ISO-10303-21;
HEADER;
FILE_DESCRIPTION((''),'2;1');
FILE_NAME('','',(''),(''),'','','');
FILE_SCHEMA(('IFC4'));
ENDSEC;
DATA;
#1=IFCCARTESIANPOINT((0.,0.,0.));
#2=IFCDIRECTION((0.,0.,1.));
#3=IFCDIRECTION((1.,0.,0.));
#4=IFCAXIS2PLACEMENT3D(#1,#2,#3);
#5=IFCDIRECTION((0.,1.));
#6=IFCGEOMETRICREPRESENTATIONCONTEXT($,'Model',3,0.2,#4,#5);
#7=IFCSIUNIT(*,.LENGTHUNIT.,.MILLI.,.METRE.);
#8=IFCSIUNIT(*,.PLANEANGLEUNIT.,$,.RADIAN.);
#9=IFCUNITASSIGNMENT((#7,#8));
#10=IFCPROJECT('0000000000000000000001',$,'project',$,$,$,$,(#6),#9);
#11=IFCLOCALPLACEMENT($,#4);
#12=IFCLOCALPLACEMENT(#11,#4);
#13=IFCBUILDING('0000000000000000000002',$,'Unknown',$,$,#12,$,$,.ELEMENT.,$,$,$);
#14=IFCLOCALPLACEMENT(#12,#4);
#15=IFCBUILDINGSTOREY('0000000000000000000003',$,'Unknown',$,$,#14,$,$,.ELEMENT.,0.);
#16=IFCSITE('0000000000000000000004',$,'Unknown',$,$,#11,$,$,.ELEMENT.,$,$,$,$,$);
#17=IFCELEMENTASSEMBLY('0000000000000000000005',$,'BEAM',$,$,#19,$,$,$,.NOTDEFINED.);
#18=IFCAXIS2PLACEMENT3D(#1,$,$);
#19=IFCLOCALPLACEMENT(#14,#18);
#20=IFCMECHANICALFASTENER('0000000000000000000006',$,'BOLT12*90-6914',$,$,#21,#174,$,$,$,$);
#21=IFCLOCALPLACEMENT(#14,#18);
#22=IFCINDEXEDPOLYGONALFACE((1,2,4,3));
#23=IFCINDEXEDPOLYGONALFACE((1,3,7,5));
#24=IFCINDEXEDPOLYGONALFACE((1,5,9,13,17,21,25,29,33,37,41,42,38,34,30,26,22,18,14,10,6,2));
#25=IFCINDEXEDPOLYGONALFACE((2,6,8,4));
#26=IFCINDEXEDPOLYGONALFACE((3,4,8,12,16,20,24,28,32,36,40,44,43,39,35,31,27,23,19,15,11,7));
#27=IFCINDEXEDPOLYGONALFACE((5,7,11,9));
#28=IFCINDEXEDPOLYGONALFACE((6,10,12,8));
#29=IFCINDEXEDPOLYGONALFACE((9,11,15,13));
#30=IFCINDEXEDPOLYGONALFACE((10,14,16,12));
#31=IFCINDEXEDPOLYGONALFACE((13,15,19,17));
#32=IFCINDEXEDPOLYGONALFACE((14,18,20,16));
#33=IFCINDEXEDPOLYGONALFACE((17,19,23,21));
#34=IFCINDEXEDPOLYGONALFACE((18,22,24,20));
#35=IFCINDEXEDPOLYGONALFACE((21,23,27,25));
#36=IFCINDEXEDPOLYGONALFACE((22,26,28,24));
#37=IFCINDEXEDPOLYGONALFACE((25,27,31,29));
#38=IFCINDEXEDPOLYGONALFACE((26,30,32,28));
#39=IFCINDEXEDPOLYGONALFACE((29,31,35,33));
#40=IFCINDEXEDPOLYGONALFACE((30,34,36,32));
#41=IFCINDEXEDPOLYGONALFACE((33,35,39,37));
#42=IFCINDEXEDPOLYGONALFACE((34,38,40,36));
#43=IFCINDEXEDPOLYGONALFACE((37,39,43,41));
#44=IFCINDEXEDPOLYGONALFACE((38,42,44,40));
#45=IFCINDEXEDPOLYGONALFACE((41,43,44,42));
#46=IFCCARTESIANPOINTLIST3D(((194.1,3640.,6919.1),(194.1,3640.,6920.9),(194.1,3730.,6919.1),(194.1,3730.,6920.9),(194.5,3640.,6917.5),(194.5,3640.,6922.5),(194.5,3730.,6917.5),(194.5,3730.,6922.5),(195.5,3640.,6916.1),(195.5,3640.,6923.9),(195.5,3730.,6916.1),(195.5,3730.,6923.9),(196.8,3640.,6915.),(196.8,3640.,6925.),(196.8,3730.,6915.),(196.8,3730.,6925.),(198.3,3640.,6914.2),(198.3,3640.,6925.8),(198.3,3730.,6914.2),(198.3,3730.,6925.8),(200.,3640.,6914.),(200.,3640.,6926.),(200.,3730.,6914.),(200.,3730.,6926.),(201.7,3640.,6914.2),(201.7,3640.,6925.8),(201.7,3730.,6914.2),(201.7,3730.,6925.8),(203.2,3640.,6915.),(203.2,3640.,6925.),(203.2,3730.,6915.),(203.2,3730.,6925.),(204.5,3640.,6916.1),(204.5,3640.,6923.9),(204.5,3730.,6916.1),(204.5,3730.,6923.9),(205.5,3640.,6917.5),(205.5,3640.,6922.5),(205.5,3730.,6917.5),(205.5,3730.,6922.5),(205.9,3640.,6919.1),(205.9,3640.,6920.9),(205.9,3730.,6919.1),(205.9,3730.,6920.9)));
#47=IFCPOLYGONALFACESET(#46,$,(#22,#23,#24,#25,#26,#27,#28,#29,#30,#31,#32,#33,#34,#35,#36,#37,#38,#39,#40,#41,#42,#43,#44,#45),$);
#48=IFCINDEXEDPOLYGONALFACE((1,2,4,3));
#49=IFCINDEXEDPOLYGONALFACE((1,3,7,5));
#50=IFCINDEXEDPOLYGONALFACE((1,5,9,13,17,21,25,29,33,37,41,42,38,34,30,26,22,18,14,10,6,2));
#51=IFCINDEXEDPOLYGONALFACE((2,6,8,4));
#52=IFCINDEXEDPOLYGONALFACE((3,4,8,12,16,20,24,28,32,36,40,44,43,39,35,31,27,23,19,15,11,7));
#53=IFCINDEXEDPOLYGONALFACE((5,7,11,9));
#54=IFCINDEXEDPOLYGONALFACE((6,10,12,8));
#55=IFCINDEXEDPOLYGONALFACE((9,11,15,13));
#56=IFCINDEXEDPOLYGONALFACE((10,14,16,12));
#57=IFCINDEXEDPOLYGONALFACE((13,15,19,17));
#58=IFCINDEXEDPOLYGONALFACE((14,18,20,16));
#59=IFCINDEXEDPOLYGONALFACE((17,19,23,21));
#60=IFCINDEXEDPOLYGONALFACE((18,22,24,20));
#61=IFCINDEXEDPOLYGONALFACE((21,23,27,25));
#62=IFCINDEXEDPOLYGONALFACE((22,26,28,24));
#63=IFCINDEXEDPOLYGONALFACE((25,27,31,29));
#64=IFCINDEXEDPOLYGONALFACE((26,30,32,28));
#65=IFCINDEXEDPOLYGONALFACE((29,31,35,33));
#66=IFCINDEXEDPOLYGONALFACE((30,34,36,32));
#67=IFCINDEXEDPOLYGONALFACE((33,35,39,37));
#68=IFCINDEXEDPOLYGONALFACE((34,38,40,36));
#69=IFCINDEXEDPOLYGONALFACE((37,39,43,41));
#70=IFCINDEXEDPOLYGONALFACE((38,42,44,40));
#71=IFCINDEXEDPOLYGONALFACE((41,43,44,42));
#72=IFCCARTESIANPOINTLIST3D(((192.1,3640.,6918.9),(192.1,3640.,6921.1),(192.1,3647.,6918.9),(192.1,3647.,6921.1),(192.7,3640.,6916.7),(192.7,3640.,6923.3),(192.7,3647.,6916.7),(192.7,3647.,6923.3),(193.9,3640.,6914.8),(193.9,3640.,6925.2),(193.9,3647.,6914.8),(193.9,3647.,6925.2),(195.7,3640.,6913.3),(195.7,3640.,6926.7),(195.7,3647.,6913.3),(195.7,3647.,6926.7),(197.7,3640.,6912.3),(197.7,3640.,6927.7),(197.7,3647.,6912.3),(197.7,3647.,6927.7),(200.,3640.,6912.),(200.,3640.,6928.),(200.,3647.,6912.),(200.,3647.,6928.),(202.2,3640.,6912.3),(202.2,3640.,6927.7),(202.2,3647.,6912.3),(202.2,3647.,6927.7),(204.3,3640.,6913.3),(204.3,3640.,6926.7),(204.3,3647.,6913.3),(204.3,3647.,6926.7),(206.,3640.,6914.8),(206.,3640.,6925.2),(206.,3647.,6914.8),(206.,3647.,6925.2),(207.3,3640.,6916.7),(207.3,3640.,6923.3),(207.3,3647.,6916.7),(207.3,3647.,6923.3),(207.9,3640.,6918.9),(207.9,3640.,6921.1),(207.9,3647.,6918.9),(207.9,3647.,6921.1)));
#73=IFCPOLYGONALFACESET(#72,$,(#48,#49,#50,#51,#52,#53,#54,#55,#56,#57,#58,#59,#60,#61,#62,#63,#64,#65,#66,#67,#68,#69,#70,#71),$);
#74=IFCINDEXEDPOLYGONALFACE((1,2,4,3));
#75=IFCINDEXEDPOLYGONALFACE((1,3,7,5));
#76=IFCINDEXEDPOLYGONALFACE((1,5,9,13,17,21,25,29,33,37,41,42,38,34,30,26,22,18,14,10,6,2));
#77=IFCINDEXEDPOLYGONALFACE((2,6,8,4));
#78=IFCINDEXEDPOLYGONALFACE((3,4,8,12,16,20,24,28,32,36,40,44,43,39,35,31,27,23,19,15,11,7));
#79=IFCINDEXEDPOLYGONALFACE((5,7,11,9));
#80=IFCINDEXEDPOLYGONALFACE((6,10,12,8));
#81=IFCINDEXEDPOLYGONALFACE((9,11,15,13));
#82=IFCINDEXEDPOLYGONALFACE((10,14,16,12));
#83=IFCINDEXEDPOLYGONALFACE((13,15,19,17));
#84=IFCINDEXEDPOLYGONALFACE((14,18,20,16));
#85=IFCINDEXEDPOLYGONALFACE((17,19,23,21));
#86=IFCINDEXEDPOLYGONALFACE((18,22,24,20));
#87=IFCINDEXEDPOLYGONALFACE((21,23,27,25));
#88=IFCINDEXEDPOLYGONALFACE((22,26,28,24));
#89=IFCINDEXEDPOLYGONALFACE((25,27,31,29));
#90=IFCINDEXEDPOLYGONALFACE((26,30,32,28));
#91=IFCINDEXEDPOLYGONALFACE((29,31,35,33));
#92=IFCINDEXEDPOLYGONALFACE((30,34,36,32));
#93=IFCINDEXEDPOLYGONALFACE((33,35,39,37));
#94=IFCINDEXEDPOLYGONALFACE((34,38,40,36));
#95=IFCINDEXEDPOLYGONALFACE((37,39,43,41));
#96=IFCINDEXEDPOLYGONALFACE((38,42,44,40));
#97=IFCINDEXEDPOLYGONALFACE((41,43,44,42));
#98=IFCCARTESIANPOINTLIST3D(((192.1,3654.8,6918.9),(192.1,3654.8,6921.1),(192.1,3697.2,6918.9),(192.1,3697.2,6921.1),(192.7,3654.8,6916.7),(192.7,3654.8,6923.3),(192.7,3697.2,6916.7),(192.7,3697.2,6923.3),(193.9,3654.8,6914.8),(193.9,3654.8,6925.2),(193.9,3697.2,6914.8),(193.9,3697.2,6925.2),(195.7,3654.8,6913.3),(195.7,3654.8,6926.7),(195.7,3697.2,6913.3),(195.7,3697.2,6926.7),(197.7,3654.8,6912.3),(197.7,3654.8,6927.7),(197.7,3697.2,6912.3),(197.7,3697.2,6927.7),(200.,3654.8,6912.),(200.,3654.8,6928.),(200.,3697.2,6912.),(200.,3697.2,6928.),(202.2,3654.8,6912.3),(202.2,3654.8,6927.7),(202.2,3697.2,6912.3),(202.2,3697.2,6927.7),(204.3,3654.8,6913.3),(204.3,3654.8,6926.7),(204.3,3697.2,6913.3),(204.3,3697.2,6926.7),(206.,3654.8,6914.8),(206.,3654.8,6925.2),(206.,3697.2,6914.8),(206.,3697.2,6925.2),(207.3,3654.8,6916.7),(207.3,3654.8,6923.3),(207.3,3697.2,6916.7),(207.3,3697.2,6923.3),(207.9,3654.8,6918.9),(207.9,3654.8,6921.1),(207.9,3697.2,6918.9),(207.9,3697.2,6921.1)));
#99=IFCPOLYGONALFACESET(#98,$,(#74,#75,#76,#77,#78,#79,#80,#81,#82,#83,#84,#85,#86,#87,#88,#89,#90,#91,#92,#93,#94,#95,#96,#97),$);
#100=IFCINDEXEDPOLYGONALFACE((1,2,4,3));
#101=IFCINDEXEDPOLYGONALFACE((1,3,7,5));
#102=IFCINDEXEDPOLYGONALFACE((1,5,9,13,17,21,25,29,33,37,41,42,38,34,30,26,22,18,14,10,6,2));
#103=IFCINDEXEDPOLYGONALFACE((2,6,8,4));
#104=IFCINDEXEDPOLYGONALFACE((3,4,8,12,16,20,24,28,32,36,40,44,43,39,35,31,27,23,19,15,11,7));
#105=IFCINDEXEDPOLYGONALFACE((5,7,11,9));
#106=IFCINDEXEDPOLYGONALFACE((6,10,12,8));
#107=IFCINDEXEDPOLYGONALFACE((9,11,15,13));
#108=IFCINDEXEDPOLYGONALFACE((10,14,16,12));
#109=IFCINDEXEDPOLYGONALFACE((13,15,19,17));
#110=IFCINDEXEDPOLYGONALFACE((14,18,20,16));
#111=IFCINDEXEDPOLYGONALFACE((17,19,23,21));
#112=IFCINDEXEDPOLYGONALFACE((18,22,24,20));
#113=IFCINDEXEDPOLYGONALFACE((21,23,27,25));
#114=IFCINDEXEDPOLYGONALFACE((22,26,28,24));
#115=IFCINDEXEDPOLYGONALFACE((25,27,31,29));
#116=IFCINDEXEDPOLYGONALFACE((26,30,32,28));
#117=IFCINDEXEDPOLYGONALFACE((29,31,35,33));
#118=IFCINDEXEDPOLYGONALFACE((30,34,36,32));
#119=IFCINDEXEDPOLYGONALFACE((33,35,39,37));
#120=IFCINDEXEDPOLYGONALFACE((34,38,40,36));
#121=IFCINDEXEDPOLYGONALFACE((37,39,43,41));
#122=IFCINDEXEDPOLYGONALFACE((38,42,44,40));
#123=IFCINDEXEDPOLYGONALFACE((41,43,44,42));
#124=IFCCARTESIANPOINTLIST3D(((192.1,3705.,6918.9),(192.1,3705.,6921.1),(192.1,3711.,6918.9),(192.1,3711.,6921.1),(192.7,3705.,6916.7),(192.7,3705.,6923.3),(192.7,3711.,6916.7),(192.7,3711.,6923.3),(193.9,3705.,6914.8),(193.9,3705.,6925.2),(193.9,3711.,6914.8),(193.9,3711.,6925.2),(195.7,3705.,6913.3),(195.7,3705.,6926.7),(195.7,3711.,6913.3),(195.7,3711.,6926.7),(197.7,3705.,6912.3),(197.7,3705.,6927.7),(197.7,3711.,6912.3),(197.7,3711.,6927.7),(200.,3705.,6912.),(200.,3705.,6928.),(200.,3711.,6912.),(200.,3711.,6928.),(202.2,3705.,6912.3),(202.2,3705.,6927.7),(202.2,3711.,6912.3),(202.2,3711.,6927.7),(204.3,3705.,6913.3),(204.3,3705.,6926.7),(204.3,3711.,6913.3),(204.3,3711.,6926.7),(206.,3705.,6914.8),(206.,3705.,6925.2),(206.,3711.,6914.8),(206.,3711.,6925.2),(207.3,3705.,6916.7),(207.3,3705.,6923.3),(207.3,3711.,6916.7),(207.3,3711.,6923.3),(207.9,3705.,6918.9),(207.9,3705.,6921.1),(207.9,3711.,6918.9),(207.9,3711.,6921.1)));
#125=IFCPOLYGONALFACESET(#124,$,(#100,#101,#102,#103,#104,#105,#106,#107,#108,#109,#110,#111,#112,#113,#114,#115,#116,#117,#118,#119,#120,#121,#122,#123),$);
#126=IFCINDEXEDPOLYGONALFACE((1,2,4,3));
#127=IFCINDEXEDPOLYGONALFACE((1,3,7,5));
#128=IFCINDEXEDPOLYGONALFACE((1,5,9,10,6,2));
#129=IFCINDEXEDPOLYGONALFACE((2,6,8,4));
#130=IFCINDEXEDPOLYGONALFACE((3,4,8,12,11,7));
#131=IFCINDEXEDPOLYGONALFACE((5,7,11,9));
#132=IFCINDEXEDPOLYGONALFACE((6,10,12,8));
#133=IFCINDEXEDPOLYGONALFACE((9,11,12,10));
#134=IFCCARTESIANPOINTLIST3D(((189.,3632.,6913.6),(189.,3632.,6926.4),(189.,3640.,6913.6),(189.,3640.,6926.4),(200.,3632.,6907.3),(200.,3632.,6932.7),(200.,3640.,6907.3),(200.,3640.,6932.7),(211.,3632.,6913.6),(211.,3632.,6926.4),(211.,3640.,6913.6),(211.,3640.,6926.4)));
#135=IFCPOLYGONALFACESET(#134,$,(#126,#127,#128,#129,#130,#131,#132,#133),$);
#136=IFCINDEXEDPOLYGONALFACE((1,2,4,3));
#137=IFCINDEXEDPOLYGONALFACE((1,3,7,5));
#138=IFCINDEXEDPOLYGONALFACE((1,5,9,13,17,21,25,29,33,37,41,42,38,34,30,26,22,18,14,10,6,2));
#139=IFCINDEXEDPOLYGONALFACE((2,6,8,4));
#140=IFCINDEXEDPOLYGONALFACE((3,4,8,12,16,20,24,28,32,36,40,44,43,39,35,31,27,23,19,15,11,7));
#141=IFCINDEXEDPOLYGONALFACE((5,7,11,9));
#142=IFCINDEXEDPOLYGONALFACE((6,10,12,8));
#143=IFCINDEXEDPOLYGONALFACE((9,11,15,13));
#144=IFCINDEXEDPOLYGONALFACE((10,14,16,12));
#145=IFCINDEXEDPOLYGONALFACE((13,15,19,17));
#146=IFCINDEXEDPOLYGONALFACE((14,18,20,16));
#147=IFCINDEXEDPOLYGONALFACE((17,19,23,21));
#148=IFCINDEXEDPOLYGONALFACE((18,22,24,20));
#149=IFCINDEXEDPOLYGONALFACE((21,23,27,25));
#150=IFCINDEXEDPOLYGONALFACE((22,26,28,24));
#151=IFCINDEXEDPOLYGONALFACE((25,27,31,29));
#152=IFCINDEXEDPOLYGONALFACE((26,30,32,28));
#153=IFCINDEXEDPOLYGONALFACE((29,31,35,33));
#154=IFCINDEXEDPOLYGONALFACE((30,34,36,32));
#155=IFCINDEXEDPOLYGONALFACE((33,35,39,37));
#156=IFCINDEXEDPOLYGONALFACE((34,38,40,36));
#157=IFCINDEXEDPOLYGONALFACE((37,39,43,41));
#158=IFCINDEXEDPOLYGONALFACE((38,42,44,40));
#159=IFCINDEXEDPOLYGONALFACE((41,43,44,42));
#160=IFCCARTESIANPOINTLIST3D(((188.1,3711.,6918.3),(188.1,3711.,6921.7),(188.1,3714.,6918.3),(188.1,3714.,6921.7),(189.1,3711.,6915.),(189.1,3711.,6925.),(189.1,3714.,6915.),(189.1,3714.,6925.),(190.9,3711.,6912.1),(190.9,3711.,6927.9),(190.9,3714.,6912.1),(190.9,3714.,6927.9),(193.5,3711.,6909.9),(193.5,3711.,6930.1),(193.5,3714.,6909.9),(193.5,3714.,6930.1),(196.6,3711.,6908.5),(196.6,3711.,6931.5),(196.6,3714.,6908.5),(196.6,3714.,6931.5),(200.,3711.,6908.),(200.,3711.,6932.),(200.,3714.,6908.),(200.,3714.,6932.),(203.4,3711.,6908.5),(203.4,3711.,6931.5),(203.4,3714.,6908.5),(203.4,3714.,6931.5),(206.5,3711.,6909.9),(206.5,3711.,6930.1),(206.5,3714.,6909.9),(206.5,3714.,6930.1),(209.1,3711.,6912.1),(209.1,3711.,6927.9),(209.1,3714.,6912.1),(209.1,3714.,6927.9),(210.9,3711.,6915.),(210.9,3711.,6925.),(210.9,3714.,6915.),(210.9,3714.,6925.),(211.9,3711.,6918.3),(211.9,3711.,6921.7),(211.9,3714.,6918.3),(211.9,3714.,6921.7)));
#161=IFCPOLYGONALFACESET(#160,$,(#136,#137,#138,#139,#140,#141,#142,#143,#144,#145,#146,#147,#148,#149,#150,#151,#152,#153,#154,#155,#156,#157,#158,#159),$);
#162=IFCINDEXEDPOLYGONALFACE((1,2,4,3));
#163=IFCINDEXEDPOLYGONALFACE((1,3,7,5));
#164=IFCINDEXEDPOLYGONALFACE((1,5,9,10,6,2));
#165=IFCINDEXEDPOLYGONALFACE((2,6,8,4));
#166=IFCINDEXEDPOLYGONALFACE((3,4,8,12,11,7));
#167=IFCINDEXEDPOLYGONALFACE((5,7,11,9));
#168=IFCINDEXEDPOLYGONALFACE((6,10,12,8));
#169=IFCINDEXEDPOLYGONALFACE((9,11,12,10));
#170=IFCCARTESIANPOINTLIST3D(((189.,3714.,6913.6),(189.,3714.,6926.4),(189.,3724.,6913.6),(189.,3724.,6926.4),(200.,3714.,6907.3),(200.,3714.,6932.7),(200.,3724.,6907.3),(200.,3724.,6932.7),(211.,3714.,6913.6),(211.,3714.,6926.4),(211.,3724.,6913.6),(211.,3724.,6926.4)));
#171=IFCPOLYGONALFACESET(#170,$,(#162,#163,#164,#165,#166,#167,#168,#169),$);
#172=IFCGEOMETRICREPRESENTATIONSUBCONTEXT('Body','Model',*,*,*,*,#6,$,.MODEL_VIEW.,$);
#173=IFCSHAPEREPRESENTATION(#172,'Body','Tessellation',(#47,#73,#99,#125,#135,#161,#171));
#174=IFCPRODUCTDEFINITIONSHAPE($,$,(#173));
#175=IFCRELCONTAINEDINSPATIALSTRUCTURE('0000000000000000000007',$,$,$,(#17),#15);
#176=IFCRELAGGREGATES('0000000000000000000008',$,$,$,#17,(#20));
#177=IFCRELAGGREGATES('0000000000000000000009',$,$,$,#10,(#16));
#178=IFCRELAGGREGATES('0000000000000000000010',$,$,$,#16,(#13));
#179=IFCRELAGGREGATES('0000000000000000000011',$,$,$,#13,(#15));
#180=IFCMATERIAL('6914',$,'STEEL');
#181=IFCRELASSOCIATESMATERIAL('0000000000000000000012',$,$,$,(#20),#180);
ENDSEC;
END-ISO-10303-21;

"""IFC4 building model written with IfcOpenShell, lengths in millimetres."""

from ifc_helpers import new_model, si_unit, direction, frame, origin_with_axes, place, context, subcontext, project, spatial, line, arc, indexed_curve, outline, extrude, source, transform, mapped, material, element, aggregate, save


model = new_model("IFC4")

# Units and contexts
model_context = context("Model", 3, precision=0.2, world=origin_with_axes(), true_north=direction((0.0, 1.0)))
body_context = subcontext(model_context, "Body", "Model", "MODEL_VIEW")
ifc_project = project(units=[si_unit("LENGTHUNIT", "METRE", prefix="MILLI"), si_unit("PLANEANGLEUNIT", "RADIAN")], contexts=[model_context])

# Site, building, storey
site_placement = place(None, origin_with_axes())
site = spatial("IfcSite", under=ifc_project, at=site_placement, Name="Unknown", CompositionType="ELEMENT")
building_placement = place(site_placement, origin_with_axes())
building = spatial("IfcBuilding", under=site, at=building_placement, Name="Unknown", CompositionType="ELEMENT")
storey_placement = place(building_placement, origin_with_axes())
storey = spatial("IfcBuildingStorey", under=building, at=storey_placement, Name="Unknown", CompositionType="ELEMENT", Elevation=0.0)

# Element assembly
assembly_1_placement = place(storey_placement, frame((175.5, 3720.0, 6980.0), z_axis=(0.0, -1.0, 0.000002), x_axis=(1.0, 0.0, 0.0)))
assembly_1 = element("IfcElementAssembly", 1, at=assembly_1_placement, inside=storey, Name="BEAM", PredefinedType="NOTDEFINED")

# Mechanical fastener
ifc_material_1 = material(Name="6914", Category="STEEL")
shared_shape_1 = source(origin_with_axes(), body_context, "Body", "SweptSolid", [
    extrude(outline(indexed_curve([(6.0, 0.0), (0.0, 6.0), (-6.0, 0.0), (0.0, -6.0)], segments=[arc(1, 2, 3), arc(3, 4, 1)])), frame((0.0, 0.0, 0.0), z_axis=(0.0, -0.000002, -1.0), x_axis=(0.0, 1.0, 0.0)), (0.0, 0.0, 1.0), 90.0),
    extrude(outline(indexed_curve([(8.0, 0.0), (0.0, 8.0), (-8.0, 0.0), (0.0, -8.0)], segments=[arc(1, 2, 3), arc(3, 4, 1)])), frame((0.0, 0.0, 0.0), z_axis=(0.0, -0.000002, -1.0), x_axis=(0.0, 1.0, 0.0)), (0.0, 0.0, 1.0), 7.0),
    extrude(outline(indexed_curve([(8.0, 0.0), (0.0, 8.0), (-8.0, 0.0), (0.0, -8.0)], segments=[arc(1, 2, 3), arc(3, 4, 1)])), frame((0.0, 0.0, -14.8), z_axis=(0.0, -0.000002, -1.0), x_axis=(0.0, 1.0, 0.0)), (0.0, 0.0, 1.0), 42.4),
    extrude(outline(indexed_curve([(8.0, 0.0), (0.0, 8.0), (-8.0, 0.0), (0.0, -8.0)], segments=[arc(1, 2, 3), arc(3, 4, 1)])), frame((0.0, 0.0, -65.0), z_axis=(0.0, -0.000002, -1.0), x_axis=(0.0, 1.0, 0.0)), (0.0, 0.0, 1.0), 6.0),
    extrude(outline(indexed_curve([(12.7, 0.0), (6.4, 11.0), (-6.4, 11.0), (-12.7, 0.0), (-6.4, -11.0), (6.4, -11.0)], segments=[line(1, 2, 3, 4, 5, 6, 1)])), frame((0.0, 0.0, 8.0), z_axis=(0.0, -0.000002, -1.0), x_axis=(0.0, 1.0, 0.0)), (0.0, 0.0, 1.0), 8.0),
    extrude(outline(indexed_curve([(12.0, 0.0), (0.0, 12.0), (-12.0, 0.0), (0.0, -12.0)], segments=[arc(1, 2, 3), arc(3, 4, 1)])), frame((0.0, 0.0, -71.0), z_axis=(0.0, -0.000002, -1.0), x_axis=(0.0, 1.0, 0.0)), (0.0, 0.0, 1.0), 3.0),
    extrude(outline(indexed_curve([(12.7, 0.0), (6.4, 11.0), (-6.4, 11.0), (-12.7, 0.0), (-6.4, -11.0), (6.4, -11.0)], segments=[line(1, 2, 3, 4, 5, 6, 1)])), frame((0.0, 0.0, -74.0), z_axis=(0.0, -0.000002, -1.0), x_axis=(0.0, 1.0, 0.0)), (0.0, 0.0, 1.0), 10.0),
])
mechanical_fastener_1_placement = place(assembly_1_placement, frame((24.5, -60.0, 80.0), z_axis=(0.0, 0.0, 1.0), x_axis=(1.0, 0.0, 0.0)))
mechanical_fastener_1 = element("IfcMechanicalFastener", 2, at=mechanical_fastener_1_placement, material=ifc_material_1, Name="BOLT12*90-6914", context=body_context, shape_type="MappedRepresentation", body=[
    mapped(shared_shape_1, transform((0.0, 0.0, 0.0))),
])
aggregate(assembly_1, [mechanical_fastener_1])

save(model, "model.ifc")
